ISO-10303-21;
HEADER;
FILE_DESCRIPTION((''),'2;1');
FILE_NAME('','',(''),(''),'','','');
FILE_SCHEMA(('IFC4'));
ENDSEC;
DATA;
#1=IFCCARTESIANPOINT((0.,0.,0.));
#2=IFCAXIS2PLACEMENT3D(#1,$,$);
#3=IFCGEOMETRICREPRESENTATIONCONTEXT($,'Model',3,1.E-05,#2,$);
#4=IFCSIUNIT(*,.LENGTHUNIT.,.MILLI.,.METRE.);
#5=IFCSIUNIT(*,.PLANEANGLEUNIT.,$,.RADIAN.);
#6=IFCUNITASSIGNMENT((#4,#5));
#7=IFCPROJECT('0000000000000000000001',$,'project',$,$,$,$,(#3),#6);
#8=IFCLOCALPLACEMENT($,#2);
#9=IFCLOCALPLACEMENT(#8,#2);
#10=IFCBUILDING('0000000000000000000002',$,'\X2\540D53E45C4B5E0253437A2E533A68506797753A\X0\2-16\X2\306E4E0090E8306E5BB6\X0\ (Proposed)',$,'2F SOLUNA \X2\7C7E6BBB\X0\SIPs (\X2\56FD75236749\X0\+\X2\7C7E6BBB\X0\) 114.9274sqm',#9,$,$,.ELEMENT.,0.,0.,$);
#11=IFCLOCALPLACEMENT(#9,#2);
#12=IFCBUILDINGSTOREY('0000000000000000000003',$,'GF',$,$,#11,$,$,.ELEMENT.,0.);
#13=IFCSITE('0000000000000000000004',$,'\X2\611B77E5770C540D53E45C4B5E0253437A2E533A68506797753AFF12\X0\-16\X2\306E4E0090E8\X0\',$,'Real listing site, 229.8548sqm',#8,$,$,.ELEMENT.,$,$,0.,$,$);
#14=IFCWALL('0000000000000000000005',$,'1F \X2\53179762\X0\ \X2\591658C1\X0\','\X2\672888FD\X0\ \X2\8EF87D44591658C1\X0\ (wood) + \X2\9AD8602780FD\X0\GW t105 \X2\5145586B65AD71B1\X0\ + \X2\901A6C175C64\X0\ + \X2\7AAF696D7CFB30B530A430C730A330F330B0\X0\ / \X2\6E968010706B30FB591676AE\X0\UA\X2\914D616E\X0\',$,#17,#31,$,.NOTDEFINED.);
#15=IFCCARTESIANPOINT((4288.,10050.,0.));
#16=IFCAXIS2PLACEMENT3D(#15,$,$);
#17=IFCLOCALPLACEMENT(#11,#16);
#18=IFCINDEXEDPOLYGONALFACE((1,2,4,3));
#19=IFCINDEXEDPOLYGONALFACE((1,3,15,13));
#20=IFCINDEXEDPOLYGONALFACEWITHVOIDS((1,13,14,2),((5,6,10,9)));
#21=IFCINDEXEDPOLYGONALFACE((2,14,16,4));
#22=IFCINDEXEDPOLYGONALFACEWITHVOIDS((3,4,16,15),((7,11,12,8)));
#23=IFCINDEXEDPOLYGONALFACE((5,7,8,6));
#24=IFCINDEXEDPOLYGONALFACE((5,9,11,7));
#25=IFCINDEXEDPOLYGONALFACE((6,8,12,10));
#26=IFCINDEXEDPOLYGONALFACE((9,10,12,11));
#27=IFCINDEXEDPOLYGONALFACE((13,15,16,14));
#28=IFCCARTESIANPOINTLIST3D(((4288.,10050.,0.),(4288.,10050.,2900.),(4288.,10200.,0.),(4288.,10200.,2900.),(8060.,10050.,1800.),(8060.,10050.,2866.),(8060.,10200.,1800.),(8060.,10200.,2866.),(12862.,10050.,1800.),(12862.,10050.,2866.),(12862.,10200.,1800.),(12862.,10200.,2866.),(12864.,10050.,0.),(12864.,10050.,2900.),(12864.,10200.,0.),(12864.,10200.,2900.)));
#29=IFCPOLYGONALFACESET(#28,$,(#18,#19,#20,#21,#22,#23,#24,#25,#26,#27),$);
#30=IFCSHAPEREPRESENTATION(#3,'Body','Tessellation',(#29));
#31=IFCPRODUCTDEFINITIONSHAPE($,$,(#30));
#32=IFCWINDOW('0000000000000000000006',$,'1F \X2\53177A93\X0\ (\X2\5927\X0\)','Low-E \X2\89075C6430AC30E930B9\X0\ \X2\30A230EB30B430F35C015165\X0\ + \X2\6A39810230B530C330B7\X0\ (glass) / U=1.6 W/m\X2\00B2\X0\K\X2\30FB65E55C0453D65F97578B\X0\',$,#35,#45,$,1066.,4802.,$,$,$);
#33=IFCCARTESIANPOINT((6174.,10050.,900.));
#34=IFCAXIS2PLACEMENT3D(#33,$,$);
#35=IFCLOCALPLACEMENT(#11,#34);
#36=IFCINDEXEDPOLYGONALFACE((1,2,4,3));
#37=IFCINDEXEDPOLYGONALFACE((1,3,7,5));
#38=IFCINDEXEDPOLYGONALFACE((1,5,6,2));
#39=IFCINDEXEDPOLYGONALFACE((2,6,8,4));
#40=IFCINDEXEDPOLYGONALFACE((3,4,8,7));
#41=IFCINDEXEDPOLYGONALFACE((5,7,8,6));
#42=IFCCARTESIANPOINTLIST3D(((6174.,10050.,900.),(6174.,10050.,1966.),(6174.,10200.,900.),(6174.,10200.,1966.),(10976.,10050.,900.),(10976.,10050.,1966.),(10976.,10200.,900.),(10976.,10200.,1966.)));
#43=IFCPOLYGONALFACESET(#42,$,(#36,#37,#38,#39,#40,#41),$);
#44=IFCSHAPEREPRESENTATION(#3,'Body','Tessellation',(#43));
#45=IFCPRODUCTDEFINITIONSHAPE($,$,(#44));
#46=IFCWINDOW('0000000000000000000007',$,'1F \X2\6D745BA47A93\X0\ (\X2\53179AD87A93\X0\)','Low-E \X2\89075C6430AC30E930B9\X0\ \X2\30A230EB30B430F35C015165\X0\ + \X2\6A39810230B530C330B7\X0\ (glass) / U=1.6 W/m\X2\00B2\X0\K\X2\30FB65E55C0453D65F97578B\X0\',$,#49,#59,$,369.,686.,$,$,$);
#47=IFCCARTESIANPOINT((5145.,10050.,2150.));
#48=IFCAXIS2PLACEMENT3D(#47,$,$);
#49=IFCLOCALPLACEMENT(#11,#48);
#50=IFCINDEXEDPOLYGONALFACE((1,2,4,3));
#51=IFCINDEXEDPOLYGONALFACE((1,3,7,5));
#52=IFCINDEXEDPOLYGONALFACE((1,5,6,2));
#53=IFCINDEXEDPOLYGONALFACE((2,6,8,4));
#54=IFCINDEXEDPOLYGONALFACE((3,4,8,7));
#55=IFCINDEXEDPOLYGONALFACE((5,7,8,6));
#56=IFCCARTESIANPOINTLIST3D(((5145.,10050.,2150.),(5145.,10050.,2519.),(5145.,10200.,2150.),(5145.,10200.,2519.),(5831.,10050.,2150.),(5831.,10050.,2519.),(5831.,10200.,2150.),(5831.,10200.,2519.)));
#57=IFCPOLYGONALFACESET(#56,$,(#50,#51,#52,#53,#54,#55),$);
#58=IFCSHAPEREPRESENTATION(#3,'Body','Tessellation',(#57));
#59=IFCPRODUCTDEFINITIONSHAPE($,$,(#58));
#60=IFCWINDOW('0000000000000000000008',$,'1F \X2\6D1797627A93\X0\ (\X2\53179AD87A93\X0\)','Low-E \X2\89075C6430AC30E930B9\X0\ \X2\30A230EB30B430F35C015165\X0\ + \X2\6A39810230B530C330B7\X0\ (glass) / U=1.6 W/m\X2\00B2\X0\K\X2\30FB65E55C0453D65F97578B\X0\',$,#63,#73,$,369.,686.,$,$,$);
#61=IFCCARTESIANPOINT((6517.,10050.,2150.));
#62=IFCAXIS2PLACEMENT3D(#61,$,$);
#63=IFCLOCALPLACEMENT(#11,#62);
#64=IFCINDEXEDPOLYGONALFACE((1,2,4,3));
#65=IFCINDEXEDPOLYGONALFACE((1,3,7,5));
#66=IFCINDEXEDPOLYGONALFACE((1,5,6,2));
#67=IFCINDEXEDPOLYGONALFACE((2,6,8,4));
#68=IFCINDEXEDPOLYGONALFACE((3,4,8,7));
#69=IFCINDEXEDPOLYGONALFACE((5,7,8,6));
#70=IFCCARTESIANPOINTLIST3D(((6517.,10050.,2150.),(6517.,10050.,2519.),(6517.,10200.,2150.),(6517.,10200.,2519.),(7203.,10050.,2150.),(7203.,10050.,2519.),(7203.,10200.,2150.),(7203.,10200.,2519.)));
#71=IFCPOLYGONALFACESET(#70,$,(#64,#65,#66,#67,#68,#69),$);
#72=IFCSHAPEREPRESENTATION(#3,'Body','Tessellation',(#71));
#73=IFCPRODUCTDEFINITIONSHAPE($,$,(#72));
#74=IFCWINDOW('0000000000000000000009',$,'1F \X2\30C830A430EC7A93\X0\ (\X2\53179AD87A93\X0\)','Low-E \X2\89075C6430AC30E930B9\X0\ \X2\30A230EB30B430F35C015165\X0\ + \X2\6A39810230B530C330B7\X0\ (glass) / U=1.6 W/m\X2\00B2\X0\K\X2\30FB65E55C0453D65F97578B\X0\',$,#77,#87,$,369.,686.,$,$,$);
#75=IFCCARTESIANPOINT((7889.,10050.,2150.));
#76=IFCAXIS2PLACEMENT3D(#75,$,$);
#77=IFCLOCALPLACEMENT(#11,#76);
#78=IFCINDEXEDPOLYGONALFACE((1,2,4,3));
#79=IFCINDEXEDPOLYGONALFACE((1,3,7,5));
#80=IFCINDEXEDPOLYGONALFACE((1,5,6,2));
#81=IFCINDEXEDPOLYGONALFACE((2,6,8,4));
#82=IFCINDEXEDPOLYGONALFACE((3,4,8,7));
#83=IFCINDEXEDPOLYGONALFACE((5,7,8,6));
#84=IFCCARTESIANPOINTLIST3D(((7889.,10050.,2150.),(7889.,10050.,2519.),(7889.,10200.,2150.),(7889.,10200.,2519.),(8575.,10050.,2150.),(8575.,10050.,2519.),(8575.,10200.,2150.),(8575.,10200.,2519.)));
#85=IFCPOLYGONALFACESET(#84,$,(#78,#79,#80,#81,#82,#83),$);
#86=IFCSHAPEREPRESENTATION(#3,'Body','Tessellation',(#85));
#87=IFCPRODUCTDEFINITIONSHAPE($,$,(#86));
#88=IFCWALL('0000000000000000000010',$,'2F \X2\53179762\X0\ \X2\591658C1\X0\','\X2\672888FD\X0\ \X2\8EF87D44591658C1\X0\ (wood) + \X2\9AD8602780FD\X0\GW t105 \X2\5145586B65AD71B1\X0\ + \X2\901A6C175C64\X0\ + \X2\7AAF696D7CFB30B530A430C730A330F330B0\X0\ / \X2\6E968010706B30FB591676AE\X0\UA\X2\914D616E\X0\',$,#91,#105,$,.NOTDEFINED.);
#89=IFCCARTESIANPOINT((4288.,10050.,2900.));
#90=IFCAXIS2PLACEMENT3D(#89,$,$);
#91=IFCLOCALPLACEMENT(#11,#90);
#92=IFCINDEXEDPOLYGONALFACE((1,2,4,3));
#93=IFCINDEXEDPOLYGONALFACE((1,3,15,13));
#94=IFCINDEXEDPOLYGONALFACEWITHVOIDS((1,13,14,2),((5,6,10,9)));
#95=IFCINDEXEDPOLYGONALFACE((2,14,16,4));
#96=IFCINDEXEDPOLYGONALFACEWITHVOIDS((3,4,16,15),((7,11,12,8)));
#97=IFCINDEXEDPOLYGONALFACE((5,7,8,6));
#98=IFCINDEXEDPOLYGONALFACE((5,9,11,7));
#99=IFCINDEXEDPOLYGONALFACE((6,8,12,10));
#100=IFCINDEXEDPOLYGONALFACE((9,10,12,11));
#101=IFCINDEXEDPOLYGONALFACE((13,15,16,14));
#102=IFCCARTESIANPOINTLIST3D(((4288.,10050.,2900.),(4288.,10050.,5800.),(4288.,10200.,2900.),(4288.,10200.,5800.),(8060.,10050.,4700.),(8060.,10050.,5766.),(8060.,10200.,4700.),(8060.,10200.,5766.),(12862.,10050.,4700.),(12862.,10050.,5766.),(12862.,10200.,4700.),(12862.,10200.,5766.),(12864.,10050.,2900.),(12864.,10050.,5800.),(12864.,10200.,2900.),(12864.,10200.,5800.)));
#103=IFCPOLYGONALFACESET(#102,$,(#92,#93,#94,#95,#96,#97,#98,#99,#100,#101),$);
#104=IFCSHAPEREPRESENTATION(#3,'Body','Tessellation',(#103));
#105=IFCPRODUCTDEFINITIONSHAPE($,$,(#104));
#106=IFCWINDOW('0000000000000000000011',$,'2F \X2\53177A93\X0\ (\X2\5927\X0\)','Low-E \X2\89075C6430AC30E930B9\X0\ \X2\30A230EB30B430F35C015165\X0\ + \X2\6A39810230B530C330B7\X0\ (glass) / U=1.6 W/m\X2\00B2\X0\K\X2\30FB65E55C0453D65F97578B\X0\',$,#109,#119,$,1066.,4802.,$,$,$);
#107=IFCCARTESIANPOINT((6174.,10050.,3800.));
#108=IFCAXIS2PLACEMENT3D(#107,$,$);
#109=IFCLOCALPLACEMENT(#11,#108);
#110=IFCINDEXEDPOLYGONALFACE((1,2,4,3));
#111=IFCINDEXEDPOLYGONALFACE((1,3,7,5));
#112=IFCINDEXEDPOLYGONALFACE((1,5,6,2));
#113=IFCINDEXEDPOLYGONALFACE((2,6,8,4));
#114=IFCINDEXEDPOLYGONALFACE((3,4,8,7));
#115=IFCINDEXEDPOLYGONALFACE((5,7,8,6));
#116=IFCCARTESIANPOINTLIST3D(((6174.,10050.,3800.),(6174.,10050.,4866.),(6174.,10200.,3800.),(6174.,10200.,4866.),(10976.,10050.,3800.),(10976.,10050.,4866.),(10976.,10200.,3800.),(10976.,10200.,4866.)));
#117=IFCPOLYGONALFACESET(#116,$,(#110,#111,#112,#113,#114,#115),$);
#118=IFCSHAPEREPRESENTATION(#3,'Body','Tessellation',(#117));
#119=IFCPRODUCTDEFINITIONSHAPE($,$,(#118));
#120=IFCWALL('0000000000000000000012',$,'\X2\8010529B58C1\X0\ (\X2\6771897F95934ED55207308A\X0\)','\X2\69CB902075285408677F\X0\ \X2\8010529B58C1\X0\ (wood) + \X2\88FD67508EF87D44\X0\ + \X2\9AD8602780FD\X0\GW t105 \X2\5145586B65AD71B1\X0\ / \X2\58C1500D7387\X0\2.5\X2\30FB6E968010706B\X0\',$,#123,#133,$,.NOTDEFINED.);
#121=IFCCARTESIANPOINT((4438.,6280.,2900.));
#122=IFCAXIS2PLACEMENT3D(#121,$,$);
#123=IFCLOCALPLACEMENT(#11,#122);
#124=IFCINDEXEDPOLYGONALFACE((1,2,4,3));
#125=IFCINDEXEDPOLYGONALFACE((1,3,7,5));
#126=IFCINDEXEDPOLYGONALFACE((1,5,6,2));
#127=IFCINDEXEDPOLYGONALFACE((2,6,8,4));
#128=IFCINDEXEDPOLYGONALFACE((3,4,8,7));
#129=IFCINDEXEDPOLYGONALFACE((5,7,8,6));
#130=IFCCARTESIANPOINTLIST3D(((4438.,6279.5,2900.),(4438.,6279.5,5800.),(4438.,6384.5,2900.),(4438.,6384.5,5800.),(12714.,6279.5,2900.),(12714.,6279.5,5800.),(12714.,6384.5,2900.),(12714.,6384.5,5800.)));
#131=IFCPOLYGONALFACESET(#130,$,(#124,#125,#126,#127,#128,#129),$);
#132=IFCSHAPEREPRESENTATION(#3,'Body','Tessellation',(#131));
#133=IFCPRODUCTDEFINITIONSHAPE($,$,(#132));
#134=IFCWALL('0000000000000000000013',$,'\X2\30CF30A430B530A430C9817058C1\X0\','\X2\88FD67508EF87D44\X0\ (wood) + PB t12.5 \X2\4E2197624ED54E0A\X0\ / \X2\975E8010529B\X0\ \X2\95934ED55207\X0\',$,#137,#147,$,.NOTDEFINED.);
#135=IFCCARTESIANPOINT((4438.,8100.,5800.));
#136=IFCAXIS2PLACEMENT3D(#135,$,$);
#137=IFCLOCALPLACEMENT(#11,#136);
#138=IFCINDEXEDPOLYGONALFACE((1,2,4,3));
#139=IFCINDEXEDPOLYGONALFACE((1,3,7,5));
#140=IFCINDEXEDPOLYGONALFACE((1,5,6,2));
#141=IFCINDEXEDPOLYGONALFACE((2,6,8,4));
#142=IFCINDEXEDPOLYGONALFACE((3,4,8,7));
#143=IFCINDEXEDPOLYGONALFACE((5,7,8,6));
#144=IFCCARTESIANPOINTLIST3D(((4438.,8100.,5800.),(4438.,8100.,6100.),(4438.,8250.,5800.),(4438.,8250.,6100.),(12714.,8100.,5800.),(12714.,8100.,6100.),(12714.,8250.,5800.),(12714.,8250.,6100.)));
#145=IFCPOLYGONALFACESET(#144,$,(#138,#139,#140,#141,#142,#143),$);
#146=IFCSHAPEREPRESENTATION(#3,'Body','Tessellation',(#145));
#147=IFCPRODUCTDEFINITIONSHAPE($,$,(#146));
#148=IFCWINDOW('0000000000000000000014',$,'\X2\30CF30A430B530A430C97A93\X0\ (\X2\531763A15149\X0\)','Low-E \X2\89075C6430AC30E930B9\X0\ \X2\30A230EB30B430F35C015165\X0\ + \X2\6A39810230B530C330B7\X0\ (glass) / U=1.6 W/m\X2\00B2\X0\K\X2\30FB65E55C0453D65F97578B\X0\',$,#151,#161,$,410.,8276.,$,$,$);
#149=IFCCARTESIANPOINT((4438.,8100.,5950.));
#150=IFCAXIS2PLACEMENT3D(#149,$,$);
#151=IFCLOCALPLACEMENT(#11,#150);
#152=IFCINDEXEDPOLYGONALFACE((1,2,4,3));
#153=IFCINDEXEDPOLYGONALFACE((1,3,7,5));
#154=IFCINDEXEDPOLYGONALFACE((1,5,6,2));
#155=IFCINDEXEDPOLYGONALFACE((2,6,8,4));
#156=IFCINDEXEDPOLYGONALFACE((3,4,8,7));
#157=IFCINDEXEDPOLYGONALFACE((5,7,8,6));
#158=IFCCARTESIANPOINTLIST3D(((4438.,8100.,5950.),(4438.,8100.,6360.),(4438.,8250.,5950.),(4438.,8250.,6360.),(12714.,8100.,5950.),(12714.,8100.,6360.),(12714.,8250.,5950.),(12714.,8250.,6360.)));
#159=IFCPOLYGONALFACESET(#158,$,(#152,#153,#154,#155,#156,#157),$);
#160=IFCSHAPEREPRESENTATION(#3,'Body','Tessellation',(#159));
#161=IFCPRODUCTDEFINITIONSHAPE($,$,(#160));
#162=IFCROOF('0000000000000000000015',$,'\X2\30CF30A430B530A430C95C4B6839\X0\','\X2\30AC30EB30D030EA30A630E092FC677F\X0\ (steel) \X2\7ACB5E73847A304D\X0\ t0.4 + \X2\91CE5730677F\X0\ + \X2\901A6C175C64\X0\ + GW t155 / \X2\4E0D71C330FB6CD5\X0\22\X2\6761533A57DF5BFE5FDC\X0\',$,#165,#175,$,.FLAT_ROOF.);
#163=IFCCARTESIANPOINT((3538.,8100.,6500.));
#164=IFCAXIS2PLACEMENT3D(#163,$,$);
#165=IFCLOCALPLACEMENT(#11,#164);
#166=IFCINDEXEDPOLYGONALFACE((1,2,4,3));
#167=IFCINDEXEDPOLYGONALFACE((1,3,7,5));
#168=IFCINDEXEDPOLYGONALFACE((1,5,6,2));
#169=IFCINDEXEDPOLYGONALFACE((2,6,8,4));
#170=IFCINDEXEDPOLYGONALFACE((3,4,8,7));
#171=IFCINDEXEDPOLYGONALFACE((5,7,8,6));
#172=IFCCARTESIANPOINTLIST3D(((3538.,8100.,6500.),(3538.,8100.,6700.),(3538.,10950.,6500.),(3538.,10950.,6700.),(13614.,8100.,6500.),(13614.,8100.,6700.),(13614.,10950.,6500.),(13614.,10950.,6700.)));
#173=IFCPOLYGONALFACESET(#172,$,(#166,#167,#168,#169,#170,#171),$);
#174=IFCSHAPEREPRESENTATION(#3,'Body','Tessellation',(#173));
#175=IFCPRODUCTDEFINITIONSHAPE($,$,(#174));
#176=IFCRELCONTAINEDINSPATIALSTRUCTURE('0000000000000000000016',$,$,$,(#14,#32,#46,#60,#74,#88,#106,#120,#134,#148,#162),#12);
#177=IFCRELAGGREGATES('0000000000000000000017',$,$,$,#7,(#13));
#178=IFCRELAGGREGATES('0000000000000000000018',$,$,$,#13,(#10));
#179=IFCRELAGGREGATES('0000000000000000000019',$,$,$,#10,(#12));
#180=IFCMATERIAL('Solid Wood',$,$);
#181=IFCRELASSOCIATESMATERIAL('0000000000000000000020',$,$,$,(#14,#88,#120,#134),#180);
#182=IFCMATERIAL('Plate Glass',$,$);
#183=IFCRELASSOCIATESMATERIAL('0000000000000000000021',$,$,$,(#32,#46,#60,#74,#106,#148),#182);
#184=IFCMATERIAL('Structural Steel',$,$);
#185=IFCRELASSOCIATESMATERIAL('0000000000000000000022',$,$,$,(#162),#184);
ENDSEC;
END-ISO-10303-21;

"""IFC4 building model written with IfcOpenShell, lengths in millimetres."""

from ifc_helpers import new_model, si_unit, frame, frame_2d, origin, place, context, project, spatial, rectangle, extrude, material, element, fill, save


model = new_model("IFC4")

# Units and contexts
model_context = context("Model", 3, precision=1e-05, world=origin())
ifc_project = project(units=[si_unit("LENGTHUNIT", "METRE", prefix="MILLI"), si_unit("PLANEANGLEUNIT", "RADIAN")], contexts=[model_context])

# Site, building, storey
site_placement = place(None, origin())
site = spatial("IfcSite", under=ifc_project, at=site_placement, Name="愛知県名古屋市千種区桐林町２-16の一部", ObjectType="Real listing site, 229.8548sqm", CompositionType="ELEMENT", RefElevation=0.0)
building_placement = place(site_placement, origin())
building = spatial("IfcBuilding", under=site, at=building_placement, Name="名古屋市千種区桐林町2-16の一部の家 (Proposed)", ObjectType="2F SOLUNA 籾殻SIPs (国産杉+籾殻) 114.9274sqm", CompositionType="ELEMENT", ElevationOfRefHeight=0.0, ElevationOfTerrain=0.0)
storey_placement = place(building_placement, origin())
storey = spatial("IfcBuildingStorey", under=building, at=storey_placement, Name="GF", CompositionType="ELEMENT", Elevation=0.0)

# Wall, openings, windows
ifc_material_1 = material(Name="Solid Wood")
wall_1_placement = place(storey_placement, frame((4288.0, 10050.0, 0.0)))
wall_1 = element("IfcWall", 1, at=wall_1_placement, inside=storey, material=ifc_material_1, Name="1F 北面 外壁", Description="木製 軸組外壁 (wood) + 高性能GW t105 充填断熱 + 通気層 + 窯業系サイディング / 準耐火・外皮UA配慮", PredefinedType="NOTDEFINED", context=model_context, shape_type="SweptSolid", body=[
    extrude(rectangle(XDim=8576.0, YDim=150.0, at=frame_2d((4288.0, 75.0))), frame((4288.0, 10050.0, 0.0)), (0.0, 0.0, 1.0), 2900.0),
])
opening_1_placement = place(storey_placement, frame((6174.0, 10050.0, 900.0)))
opening_1 = element("IfcOpeningElement", 2, at=opening_1_placement, cuts=wall_1, PredefinedType="NOTDEFINED", context=model_context, shape_type="SweptSolid", body=[
    extrude(rectangle(XDim=4802.0, YDim=150.0, at=frame_2d((2401.0, 75.0))), frame((6174.0, 10050.0, 900.0)), (0.0, 0.0, 1.0), 1066.0),
])
opening_2_placement = place(storey_placement, frame((5145.0, 10050.0, 2150.0)))
opening_2 = element("IfcOpeningElement", 3, at=opening_2_placement, cuts=wall_1, PredefinedType="NOTDEFINED", context=model_context, shape_type="SweptSolid", body=[
    extrude(rectangle(XDim=686.0, YDim=150.0, at=frame_2d((343.0, 75.0))), frame((5145.0, 10050.0, 2150.0)), (0.0, 0.0, 1.0), 369.0),
])
opening_3_placement = place(storey_placement, frame((6517.0, 10050.0, 2150.0)))
opening_3 = element("IfcOpeningElement", 4, at=opening_3_placement, cuts=wall_1, PredefinedType="NOTDEFINED", context=model_context, shape_type="SweptSolid", body=[
    extrude(rectangle(XDim=686.0, YDim=150.0, at=frame_2d((343.0, 75.0))), frame((6517.0, 10050.0, 2150.0)), (0.0, 0.0, 1.0), 369.0),
])
opening_4_placement = place(storey_placement, frame((7889.0, 10050.0, 2150.0)))
opening_4 = element("IfcOpeningElement", 5, at=opening_4_placement, cuts=wall_1, PredefinedType="NOTDEFINED", context=model_context, shape_type="SweptSolid", body=[
    extrude(rectangle(XDim=686.0, YDim=150.0, at=frame_2d((343.0, 75.0))), frame((7889.0, 10050.0, 2150.0)), (0.0, 0.0, 1.0), 369.0),
])
ifc_material_2 = material(Name="Plate Glass")
window_1_placement = place(storey_placement, frame((6174.0, 10050.0, 900.0)))
window_1 = element("IfcWindow", 6, at=window_1_placement, inside=storey, material=ifc_material_2, Name="1F 北窓 (大)", Description="Low-E 複層ガラス アルゴン封入 + 樹脂サッシ (glass) / U=1.6 W/m²K・日射取得型", OverallHeight=1066.0, OverallWidth=4802.0, context=model_context, shape_type="SweptSolid", body=[
    extrude(rectangle(XDim=4802.0, YDim=150.0, at=frame_2d((2401.0, 75.0))), frame((6174.0, 10050.0, 900.0)), (0.0, 0.0, 1.0), 1066.0),
])
fill(opening_1, window_1)
window_2_placement = place(storey_placement, frame((5145.0, 10050.0, 2150.0)))
window_2 = element("IfcWindow", 7, at=window_2_placement, inside=storey, material=ifc_material_2, Name="1F 浴室窓 (北高窓)", Description="Low-E 複層ガラス アルゴン封入 + 樹脂サッシ (glass) / U=1.6 W/m²K・日射取得型", OverallHeight=369.0, OverallWidth=686.0, context=model_context, shape_type="SweptSolid", body=[
    extrude(rectangle(XDim=686.0, YDim=150.0, at=frame_2d((343.0, 75.0))), frame((5145.0, 10050.0, 2150.0)), (0.0, 0.0, 1.0), 369.0),
])
fill(opening_2, window_2)
window_3_placement = place(storey_placement, frame((6517.0, 10050.0, 2150.0)))
window_3 = element("IfcWindow", 8, at=window_3_placement, inside=storey, material=ifc_material_2, Name="1F 洗面窓 (北高窓)", Description="Low-E 複層ガラス アルゴン封入 + 樹脂サッシ (glass) / U=1.6 W/m²K・日射取得型", OverallHeight=369.0, OverallWidth=686.0, context=model_context, shape_type="SweptSolid", body=[
    extrude(rectangle(XDim=686.0, YDim=150.0, at=frame_2d((343.0, 75.0))), frame((6517.0, 10050.0, 2150.0)), (0.0, 0.0, 1.0), 369.0),
])
fill(opening_3, window_3)
window_4_placement = place(storey_placement, frame((7889.0, 10050.0, 2150.0)))
window_4 = element("IfcWindow", 9, at=window_4_placement, inside=storey, material=ifc_material_2, Name="1F トイレ窓 (北高窓)", Description="Low-E 複層ガラス アルゴン封入 + 樹脂サッシ (glass) / U=1.6 W/m²K・日射取得型", OverallHeight=369.0, OverallWidth=686.0, context=model_context, shape_type="SweptSolid", body=[
    extrude(rectangle(XDim=686.0, YDim=150.0, at=frame_2d((343.0, 75.0))), frame((7889.0, 10050.0, 2150.0)), (0.0, 0.0, 1.0), 369.0),
])
fill(opening_4, window_4)

# Wall, opening, window
wall_2_placement = place(storey_placement, frame((4288.0, 10050.0, 2900.0)))
wall_2 = element("IfcWall", 10, at=wall_2_placement, inside=storey, material=ifc_material_1, Name="2F 北面 外壁", Description="木製 軸組外壁 (wood) + 高性能GW t105 充填断熱 + 通気層 + 窯業系サイディング / 準耐火・外皮UA配慮", PredefinedType="NOTDEFINED", context=model_context, shape_type="SweptSolid", body=[
    extrude(rectangle(XDim=8576.0, YDim=150.0, at=frame_2d((4288.0, 75.0))), frame((4288.0, 10050.0, 2900.0)), (0.0, 0.0, 1.0), 2900.0),
])
opening_5_placement = place(storey_placement, frame((6174.0, 10050.0, 3800.0)))
opening_5 = element("IfcOpeningElement", 11, at=opening_5_placement, cuts=wall_2, PredefinedType="NOTDEFINED", context=model_context, shape_type="SweptSolid", body=[
    extrude(rectangle(XDim=4802.0, YDim=150.0, at=frame_2d((2401.0, 75.0))), frame((6174.0, 10050.0, 3800.0)), (0.0, 0.0, 1.0), 1066.0),
])
window_5_placement = place(storey_placement, frame((6174.0, 10050.0, 3800.0)))
window_5 = element("IfcWindow", 12, at=window_5_placement, inside=storey, material=ifc_material_2, Name="2F 北窓 (大)", Description="Low-E 複層ガラス アルゴン封入 + 樹脂サッシ (glass) / U=1.6 W/m²K・日射取得型", OverallHeight=1066.0, OverallWidth=4802.0, context=model_context, shape_type="SweptSolid", body=[
    extrude(rectangle(XDim=4802.0, YDim=150.0, at=frame_2d((2401.0, 75.0))), frame((6174.0, 10050.0, 3800.0)), (0.0, 0.0, 1.0), 1066.0),
])
fill(opening_5, window_5)

# Wall
wall_3_placement = place(storey_placement, frame((4438.0, 6280.0, 2900.0)))
element("IfcWall", 13, at=wall_3_placement, inside=storey, material=ifc_material_1, Name="耐力壁 (東西間仕切り)", Description="構造用合板 耐力壁 (wood) + 製材軸組 + 高性能GW t105 充填断熱 / 壁倍率2.5・準耐火", PredefinedType="NOTDEFINED", context=model_context, shape_type="SweptSolid", body=[
    extrude(rectangle(XDim=8276.0, YDim=105.0, at=frame_2d((4138.0, 52.0))), frame((4438.0, 6280.0, 2900.0)), (0.0, 0.0, 1.0), 2900.0),
])

# Wall, opening, window
wall_4_placement = place(storey_placement, frame((4438.0, 8100.0, 5800.0)))
wall_4 = element("IfcWall", 14, at=wall_4_placement, inside=storey, material=ifc_material_1, Name="ハイサイド腰壁", Description="製材軸組 (wood) + PB t12.5 両面仕上 / 非耐力 間仕切", PredefinedType="NOTDEFINED", context=model_context, shape_type="SweptSolid", body=[
    extrude(rectangle(XDim=8276.0, YDim=150.0, at=frame_2d((4138.0, 75.0))), frame((4438.0, 8100.0, 5800.0)), (0.0, 0.0, 1.0), 700.0),
])
opening_6_placement = place(storey_placement, frame((4438.0, 8100.0, 5950.0)))
opening_6 = element("IfcOpeningElement", 15, at=opening_6_placement, cuts=wall_4, PredefinedType="NOTDEFINED", context=model_context, shape_type="SweptSolid", body=[
    extrude(rectangle(XDim=8276.0, YDim=150.0, at=frame_2d((4138.0, 75.0))), frame((4438.0, 8100.0, 5950.0)), (0.0, 0.0, 1.0), 410.0),
])
window_6_placement = place(storey_placement, frame((4438.0, 8100.0, 5950.0)))
window_6 = element("IfcWindow", 16, at=window_6_placement, inside=storey, material=ifc_material_2, Name="ハイサイド窓 (北採光)", Description="Low-E 複層ガラス アルゴン封入 + 樹脂サッシ (glass) / U=1.6 W/m²K・日射取得型", OverallHeight=410.0, OverallWidth=8276.0, context=model_context, shape_type="SweptSolid", body=[
    extrude(rectangle(XDim=8276.0, YDim=150.0, at=frame_2d((4138.0, 75.0))), frame((4438.0, 8100.0, 5950.0)), (0.0, 0.0, 1.0), 410.0),
])
fill(opening_6, window_6)

# Roof
ifc_material_3 = material(Name="Structural Steel")
roof_placement = place(storey_placement, frame((3538.0, 8100.0, 6500.0)))
element("IfcRoof", 17, at=roof_placement, inside=storey, material=ifc_material_3, Name="ハイサイド屋根", Description="ガルバリウム鋼板 (steel) 立平葺き t0.4 + 野地板 + 通気層 + GW t155 / 不燃・法22条区域対応", PredefinedType="FLAT_ROOF", context=model_context, shape_type="SweptSolid", body=[
    extrude(rectangle(XDim=10076.0, YDim=2850.0, at=frame_2d((5038.0, 1425.0))), frame((3538.0, 8100.0, 6500.0)), (0.0, 0.0, 1.0), 200.0),
])

save(model, "model.ifc")
